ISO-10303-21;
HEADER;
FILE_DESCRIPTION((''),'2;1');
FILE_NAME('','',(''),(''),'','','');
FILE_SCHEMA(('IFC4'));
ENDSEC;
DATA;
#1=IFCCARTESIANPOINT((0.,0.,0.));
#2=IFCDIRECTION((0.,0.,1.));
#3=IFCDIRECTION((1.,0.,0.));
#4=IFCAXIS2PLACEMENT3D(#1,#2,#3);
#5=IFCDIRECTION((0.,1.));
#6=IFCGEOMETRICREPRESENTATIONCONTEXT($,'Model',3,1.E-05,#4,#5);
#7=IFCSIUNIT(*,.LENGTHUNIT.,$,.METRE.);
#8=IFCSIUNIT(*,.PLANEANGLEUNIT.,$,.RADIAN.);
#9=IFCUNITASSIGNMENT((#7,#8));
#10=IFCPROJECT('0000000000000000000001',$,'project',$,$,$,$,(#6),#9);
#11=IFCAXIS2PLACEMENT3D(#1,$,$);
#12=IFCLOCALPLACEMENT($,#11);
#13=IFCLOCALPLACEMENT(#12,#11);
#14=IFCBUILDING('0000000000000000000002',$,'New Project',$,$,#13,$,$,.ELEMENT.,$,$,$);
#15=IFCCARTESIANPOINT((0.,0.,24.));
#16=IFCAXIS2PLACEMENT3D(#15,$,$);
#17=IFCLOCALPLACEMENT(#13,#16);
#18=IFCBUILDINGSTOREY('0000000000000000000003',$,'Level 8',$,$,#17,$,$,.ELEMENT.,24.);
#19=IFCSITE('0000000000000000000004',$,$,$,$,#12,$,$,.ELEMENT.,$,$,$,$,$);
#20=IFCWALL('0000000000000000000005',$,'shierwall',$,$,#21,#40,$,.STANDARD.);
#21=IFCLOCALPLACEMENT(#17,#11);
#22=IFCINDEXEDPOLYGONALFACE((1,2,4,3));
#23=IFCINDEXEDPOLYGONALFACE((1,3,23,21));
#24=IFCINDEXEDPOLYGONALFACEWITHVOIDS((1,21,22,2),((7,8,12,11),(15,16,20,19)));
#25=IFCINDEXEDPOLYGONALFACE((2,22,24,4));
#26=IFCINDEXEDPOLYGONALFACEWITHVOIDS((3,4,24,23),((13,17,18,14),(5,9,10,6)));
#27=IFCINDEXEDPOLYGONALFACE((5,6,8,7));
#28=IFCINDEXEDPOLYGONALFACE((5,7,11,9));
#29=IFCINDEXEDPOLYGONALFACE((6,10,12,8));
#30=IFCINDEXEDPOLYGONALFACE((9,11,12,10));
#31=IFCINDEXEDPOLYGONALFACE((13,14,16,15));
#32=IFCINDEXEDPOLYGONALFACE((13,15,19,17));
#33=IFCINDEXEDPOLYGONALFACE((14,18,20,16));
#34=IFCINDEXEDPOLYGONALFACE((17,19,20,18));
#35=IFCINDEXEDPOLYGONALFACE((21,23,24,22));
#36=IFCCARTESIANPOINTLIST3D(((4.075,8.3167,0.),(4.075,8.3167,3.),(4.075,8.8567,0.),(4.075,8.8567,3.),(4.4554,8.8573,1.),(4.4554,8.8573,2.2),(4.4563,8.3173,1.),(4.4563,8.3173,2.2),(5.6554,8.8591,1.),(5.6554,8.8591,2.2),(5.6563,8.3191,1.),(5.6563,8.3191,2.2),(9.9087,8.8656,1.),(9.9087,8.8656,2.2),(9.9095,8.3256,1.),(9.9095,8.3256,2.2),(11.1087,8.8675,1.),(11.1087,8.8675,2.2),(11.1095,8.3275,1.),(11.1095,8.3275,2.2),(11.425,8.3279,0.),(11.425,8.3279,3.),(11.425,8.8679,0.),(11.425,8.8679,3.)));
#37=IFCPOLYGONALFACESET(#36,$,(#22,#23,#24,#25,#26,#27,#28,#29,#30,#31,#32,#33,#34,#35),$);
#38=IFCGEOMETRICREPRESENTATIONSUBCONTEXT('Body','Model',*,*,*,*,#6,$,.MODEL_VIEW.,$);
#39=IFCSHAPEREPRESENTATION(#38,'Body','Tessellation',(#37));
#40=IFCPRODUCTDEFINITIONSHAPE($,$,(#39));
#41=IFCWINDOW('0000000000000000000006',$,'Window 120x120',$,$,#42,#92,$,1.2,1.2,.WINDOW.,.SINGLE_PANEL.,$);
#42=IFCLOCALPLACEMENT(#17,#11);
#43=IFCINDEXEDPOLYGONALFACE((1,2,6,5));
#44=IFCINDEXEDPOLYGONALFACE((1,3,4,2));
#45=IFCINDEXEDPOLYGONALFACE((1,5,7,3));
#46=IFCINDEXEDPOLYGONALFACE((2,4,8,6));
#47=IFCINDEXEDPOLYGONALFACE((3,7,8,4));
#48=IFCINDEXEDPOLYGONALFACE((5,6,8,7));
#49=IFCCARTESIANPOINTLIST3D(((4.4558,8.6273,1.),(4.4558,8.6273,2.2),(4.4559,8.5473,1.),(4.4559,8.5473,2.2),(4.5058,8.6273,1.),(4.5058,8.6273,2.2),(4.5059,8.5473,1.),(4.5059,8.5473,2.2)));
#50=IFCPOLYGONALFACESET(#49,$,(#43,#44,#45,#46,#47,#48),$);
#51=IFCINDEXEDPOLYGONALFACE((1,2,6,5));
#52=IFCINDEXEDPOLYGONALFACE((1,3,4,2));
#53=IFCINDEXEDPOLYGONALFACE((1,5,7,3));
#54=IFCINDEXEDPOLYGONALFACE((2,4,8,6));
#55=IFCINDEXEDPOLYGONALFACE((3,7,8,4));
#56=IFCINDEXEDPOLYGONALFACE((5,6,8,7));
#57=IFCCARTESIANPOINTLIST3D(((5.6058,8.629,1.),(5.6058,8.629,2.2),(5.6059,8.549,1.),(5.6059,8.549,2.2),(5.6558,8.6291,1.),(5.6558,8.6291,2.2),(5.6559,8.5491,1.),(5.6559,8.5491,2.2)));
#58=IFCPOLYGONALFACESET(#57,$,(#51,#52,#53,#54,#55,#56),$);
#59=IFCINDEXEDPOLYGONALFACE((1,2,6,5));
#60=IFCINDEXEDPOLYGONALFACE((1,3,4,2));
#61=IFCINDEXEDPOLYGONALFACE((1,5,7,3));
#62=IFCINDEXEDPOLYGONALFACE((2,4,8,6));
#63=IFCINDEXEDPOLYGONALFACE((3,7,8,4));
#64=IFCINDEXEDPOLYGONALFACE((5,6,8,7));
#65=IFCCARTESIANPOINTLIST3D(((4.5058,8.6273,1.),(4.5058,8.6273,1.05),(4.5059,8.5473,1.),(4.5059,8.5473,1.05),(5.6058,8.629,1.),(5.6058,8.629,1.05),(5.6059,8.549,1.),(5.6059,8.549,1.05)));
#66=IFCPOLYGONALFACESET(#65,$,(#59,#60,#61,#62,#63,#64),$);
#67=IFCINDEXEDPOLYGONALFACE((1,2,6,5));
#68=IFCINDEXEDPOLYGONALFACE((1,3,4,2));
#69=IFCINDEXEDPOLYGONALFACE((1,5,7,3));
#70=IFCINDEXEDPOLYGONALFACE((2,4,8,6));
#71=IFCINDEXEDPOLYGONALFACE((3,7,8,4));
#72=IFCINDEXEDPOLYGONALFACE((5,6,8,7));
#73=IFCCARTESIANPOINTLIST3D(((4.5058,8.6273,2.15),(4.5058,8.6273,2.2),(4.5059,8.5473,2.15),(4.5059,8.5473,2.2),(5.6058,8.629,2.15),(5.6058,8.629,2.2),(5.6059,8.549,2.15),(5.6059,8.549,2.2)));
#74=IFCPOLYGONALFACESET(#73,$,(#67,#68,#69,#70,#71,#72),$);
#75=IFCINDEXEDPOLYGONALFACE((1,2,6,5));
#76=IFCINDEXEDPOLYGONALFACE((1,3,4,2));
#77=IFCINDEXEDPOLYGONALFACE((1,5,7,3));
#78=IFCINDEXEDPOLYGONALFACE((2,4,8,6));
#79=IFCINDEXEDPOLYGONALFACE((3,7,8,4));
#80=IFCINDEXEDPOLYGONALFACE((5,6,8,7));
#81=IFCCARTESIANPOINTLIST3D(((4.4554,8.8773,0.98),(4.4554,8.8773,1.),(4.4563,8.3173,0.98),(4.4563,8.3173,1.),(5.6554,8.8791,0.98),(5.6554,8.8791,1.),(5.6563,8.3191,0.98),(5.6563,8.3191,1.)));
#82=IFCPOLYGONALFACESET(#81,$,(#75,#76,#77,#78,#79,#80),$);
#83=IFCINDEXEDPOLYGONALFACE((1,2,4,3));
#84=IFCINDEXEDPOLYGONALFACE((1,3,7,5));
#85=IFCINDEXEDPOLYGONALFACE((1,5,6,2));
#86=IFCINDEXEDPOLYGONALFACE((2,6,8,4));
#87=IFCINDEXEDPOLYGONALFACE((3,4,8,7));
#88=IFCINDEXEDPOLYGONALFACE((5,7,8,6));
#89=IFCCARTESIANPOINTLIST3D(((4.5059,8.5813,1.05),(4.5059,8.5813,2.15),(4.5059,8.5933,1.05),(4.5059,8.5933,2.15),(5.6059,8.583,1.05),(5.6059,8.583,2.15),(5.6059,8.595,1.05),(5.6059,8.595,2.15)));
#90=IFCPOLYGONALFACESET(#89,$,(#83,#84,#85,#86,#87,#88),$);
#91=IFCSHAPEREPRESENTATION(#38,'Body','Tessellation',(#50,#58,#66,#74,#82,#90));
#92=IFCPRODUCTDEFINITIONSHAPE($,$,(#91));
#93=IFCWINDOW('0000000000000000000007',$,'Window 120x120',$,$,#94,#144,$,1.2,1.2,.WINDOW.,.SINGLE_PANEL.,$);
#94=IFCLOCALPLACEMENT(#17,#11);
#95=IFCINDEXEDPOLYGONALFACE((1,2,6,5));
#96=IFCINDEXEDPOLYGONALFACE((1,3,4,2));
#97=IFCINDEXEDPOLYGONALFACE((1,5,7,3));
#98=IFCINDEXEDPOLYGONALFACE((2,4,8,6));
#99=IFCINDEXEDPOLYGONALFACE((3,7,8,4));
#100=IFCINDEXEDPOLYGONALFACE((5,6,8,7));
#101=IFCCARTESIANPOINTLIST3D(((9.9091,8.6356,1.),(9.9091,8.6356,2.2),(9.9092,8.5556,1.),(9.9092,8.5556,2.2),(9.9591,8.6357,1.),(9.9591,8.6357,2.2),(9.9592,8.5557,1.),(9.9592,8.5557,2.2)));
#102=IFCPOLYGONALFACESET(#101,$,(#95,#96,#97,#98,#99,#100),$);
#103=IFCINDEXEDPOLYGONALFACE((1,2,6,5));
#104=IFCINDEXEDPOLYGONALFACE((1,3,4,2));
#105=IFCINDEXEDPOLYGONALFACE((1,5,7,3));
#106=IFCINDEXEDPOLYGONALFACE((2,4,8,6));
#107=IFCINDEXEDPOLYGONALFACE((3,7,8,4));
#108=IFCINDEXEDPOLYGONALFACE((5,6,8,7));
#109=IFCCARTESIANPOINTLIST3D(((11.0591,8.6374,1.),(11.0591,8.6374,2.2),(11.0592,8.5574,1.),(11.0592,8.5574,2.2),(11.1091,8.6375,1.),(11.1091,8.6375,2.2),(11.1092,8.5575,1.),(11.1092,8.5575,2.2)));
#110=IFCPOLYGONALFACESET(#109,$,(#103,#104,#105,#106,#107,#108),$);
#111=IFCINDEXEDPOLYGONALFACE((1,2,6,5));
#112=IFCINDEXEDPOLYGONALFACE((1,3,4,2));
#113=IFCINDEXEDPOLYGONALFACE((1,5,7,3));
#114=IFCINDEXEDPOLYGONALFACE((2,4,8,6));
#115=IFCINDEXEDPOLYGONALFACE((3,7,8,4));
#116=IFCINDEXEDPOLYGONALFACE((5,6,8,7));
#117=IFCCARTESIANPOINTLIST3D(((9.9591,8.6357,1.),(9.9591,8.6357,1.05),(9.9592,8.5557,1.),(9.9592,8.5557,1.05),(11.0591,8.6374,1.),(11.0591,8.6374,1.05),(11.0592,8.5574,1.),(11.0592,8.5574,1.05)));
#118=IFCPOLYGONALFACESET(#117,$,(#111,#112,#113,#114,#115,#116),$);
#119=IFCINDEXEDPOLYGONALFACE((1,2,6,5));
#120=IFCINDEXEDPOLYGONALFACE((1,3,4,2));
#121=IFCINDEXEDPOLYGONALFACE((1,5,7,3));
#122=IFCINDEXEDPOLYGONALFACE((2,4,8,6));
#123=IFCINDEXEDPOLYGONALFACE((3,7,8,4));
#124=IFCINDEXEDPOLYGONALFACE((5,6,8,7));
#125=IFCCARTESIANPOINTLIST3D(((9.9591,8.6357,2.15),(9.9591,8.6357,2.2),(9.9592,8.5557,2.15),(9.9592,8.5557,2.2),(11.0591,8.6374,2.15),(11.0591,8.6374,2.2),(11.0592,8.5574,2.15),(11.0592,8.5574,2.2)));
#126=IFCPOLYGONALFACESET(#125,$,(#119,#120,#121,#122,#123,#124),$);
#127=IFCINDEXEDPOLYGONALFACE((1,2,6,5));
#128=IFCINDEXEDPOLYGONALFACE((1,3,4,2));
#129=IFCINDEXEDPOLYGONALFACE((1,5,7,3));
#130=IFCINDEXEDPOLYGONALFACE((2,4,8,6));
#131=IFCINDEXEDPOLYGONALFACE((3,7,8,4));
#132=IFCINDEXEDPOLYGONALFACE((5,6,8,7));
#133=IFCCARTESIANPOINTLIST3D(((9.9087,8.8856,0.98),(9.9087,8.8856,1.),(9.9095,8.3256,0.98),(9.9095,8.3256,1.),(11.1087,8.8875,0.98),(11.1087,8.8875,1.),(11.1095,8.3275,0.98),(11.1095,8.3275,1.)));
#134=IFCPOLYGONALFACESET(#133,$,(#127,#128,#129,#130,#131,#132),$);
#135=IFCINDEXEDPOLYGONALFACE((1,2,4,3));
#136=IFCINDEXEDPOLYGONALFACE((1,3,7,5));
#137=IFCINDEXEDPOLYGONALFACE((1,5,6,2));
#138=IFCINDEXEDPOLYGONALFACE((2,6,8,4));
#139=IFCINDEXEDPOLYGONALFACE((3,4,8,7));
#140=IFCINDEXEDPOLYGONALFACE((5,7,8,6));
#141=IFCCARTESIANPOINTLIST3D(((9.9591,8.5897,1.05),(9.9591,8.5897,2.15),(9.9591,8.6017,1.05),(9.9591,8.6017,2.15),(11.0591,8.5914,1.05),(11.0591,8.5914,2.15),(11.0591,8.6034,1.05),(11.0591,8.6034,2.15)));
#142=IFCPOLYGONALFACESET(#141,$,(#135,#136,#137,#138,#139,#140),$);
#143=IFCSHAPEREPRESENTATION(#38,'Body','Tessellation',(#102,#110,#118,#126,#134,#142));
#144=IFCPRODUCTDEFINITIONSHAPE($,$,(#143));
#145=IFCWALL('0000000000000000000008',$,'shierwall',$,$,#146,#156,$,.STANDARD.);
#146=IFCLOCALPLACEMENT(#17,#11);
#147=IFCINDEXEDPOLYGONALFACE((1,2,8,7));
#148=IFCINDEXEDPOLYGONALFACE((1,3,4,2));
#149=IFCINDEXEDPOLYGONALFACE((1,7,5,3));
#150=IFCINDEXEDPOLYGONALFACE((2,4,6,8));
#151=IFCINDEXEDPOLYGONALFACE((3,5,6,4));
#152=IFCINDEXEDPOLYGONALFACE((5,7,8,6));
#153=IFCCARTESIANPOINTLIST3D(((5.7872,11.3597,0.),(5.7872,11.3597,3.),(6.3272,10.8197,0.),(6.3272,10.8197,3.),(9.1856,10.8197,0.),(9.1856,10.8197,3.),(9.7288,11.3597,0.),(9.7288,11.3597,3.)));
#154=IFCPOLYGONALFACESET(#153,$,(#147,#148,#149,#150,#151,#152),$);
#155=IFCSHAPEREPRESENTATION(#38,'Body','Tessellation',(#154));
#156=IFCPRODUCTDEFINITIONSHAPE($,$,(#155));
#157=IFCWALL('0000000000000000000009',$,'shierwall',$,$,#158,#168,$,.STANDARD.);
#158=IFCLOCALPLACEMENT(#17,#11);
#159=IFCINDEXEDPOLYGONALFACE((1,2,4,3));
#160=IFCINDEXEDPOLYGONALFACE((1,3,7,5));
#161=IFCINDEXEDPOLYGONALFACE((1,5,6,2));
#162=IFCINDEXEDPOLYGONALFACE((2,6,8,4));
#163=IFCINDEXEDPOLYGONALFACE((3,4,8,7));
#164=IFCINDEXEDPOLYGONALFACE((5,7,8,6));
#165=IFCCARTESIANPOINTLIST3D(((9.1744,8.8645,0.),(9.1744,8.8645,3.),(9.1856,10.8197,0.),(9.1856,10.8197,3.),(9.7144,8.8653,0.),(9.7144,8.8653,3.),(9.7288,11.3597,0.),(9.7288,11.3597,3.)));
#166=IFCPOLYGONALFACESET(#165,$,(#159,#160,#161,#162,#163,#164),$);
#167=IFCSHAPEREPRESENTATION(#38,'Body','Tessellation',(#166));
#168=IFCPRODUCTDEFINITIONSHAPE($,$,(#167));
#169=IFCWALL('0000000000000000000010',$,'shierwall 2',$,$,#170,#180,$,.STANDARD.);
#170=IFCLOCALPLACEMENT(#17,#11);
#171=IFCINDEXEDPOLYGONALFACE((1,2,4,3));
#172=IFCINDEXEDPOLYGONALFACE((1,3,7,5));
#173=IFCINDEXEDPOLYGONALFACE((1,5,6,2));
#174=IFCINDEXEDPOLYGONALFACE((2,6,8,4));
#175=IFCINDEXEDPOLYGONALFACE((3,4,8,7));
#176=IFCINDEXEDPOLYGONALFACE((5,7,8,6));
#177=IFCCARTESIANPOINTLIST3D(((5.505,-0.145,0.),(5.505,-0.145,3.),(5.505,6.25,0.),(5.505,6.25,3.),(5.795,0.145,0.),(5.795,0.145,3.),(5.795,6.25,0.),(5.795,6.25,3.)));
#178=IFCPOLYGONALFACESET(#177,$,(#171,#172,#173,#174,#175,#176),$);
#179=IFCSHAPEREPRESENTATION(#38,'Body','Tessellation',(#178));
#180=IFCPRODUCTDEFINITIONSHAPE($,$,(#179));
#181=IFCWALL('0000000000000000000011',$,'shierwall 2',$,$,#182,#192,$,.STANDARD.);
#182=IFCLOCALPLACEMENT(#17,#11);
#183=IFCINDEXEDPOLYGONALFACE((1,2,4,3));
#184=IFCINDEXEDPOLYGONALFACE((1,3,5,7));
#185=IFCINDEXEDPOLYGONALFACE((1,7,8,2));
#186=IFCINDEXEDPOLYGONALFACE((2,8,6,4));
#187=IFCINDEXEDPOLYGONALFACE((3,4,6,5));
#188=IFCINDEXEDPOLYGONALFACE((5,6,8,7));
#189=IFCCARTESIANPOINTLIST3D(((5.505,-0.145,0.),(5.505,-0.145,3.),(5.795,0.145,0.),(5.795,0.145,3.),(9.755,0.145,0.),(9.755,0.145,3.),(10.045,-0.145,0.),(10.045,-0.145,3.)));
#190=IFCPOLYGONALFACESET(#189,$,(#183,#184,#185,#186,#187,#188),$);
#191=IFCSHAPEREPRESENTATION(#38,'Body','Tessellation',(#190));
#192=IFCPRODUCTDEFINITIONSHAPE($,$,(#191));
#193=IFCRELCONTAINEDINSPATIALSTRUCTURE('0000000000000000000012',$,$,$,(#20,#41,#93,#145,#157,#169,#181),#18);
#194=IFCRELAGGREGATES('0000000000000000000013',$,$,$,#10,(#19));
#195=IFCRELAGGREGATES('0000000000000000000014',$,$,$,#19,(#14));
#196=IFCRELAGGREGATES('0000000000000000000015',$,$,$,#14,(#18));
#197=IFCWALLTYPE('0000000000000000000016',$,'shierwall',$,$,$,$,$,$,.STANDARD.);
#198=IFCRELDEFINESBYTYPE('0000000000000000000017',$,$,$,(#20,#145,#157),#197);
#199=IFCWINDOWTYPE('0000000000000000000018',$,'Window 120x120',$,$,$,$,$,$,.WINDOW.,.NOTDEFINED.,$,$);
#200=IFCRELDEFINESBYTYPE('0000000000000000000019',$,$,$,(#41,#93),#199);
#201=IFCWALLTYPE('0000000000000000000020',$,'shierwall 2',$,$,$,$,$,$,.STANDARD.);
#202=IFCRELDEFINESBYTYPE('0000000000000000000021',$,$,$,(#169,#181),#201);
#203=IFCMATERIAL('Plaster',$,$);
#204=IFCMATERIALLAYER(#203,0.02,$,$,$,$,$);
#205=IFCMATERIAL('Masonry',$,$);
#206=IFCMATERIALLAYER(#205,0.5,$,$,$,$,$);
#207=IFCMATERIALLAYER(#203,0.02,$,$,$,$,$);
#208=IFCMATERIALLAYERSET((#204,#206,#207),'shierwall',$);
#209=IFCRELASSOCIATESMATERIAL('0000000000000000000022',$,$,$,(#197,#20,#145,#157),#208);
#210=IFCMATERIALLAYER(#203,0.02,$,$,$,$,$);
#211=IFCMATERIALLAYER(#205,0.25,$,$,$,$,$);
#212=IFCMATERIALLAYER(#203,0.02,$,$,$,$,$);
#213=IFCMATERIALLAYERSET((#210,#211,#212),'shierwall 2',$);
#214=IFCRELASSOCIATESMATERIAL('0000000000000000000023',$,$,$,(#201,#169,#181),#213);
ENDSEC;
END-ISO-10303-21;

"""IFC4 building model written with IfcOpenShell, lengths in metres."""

from ifc_helpers import new_model, si_unit, direction, frame, frame_2d, origin, origin_with_axes, place, context, subcontext, project, spatial, polyline, rectangle, outline, extrude, material, layer, layer_set, layer_usage, type_object, element, fill, save


model = new_model("IFC4")

# Units and contexts
model_context = context("Model", 3, precision=1e-05, world=origin_with_axes(), true_north=direction((0.0, 1.0)))
body_context = subcontext(model_context, "Body", "Model", "MODEL_VIEW")
ifc_project = project(units=[si_unit("LENGTHUNIT", "METRE"), si_unit("PLANEANGLEUNIT", "RADIAN")], contexts=[model_context])

# Site, building, storey
site_placement = place(None, origin())
site = spatial("IfcSite", under=ifc_project, at=site_placement, CompositionType="ELEMENT")
building_placement = place(site_placement, origin())
building = spatial("IfcBuilding", under=site, at=building_placement, Name="New Project", CompositionType="ELEMENT")
storey_placement = place(building_placement, frame((0.0, 0.0, 24.0)))
storey = spatial("IfcBuildingStorey", under=building, at=storey_placement, Name="Level 8", CompositionType="ELEMENT", Elevation=24.0)

# Shared definitions
ifc_material_1 = material(Name="Plaster")
ifc_material_2 = material(Name="Masonry")

# Shared definitions
window_type = type_object("IfcWindowType", Name="Window 120x120", PartitioningType="NOTDEFINED", PredefinedType="WINDOW")

# Wall, openings, windows
ifc_layer_1 = layer(ifc_material_1, 0.02)
ifc_layer_2 = layer(ifc_material_2, 0.5)
ifc_layer_3 = layer(ifc_material_1, 0.02)
ifc_layer_set_1 = layer_set([ifc_layer_1, ifc_layer_2, ifc_layer_3], Name="shierwall")
ifc_layer_usage_1 = layer_usage(ifc_layer_set_1, "AXIS2", "NEGATIVE", 0.27)
wall_type_1 = type_object("IfcWallType", Name="shierwall", PredefinedType="STANDARD", material=ifc_layer_set_1)
wall_1_placement = place(storey_placement, frame((4.075, 8.5867, 0.0), z_axis=(0.0, 0.0, 1.0), x_axis=(0.999999, 0.001534, 0.0)))
wall_1 = element("IfcWall", 1, at=wall_1_placement, inside=storey, type_object=wall_type_1, material=ifc_layer_usage_1, Name="shierwall", PredefinedType="STANDARD", context=body_context, shape_type="SweptSolid", body=[
    extrude(outline(polyline([(-0.0004, -0.27), (7.3496, -0.27), (7.3504, 0.27), (0.0004, 0.27), (-0.0004, -0.27)])), origin(), (0.0, 0.0, 1.0), 3.0),
])
opening_1_placement = place(wall_1_placement, frame((0.3809, 0.0, 1.0)))
opening_1 = element("IfcOpeningElement", 2, at=opening_1_placement, cuts=wall_1, PredefinedType="OPENING", context=body_context, shape_type="SweptSolid", body=[
    extrude(rectangle(XDim=1.2, YDim=0.64, at=frame_2d((0.6, 0.0))), origin(), (0.0, 0.0, 1.0), 1.2),
])
opening_2_placement = place(wall_1_placement, frame((5.8341, 0.0, 1.0)))
opening_2 = element("IfcOpeningElement", 3, at=opening_2_placement, cuts=wall_1, PredefinedType="OPENING", context=body_context, shape_type="SweptSolid", body=[
    extrude(rectangle(XDim=1.2, YDim=0.64, at=frame_2d((0.6, 0.0))), origin(), (0.0, 0.0, 1.0), 1.2),
])
window_1_placement = place(opening_1_placement, origin())
window_1 = element("IfcWindow", 4, at=window_1_placement, inside=storey, type_object=window_type, Name="Window 120x120", OverallHeight=1.2, OverallWidth=1.2, PartitioningType="SINGLE_PANEL", PredefinedType="WINDOW", context=body_context, shape_type="SweptSolid", body=[
    extrude(outline(polyline([(0.0, -0.04), (0.05, -0.04), (0.05, 0.04), (0.0, 0.04), (0.0, -0.04)])), origin(), (0.0, 0.0, 1.0), 1.2),
    extrude(outline(polyline([(1.15, -0.04), (1.2, -0.04), (1.2, 0.04), (1.15, 0.04), (1.15, -0.04)])), origin(), (0.0, 0.0, 1.0), 1.2),
    extrude(outline(polyline([(0.05, -0.04), (1.15, -0.04), (1.15, 0.04), (0.05, 0.04), (0.05, -0.04)])), origin(), (0.0, 0.0, 1.0), 0.05),
    extrude(outline(polyline([(0.05, -0.04), (1.15, -0.04), (1.15, 0.04), (0.05, 0.04), (0.05, -0.04)])), frame((0.0, 0.0, 1.15)), (0.0, 0.0, 1.0), 0.05),
    extrude(outline(polyline([(0.0, -0.27), (1.2, -0.27), (1.2, 0.29), (0.0, 0.29), (0.0, -0.27)])), frame((0.0, 0.0, -0.02)), (0.0, 0.0, 1.0), 0.02),
    extrude(outline(polyline([(0.05, -0.006), (1.15, -0.006), (1.15, 0.006), (0.05, 0.006), (0.05, -0.006)])), frame((0.0, 0.0, 0.05)), (0.0, 0.0, 1.0), 1.1),
])
fill(opening_1, window_1)
window_2_placement = place(opening_2_placement, origin())
window_2 = element("IfcWindow", 5, at=window_2_placement, inside=storey, type_object=window_type, Name="Window 120x120", OverallHeight=1.2, OverallWidth=1.2, PartitioningType="SINGLE_PANEL", PredefinedType="WINDOW", context=body_context, shape_type="SweptSolid", body=[
    extrude(outline(polyline([(0.0, -0.04), (0.05, -0.04), (0.05, 0.04), (0.0, 0.04), (0.0, -0.04)])), origin(), (0.0, 0.0, 1.0), 1.2),
    extrude(outline(polyline([(1.15, -0.04), (1.2, -0.04), (1.2, 0.04), (1.15, 0.04), (1.15, -0.04)])), origin(), (0.0, 0.0, 1.0), 1.2),
    extrude(outline(polyline([(0.05, -0.04), (1.15, -0.04), (1.15, 0.04), (0.05, 0.04), (0.05, -0.04)])), origin(), (0.0, 0.0, 1.0), 0.05),
    extrude(outline(polyline([(0.05, -0.04), (1.15, -0.04), (1.15, 0.04), (0.05, 0.04), (0.05, -0.04)])), frame((0.0, 0.0, 1.15)), (0.0, 0.0, 1.0), 0.05),
    extrude(outline(polyline([(0.0, -0.27), (1.2, -0.27), (1.2, 0.29), (0.0, 0.29), (0.0, -0.27)])), frame((0.0, 0.0, -0.02)), (0.0, 0.0, 1.0), 0.02),
    extrude(outline(polyline([(0.05, -0.006), (1.15, -0.006), (1.15, 0.006), (0.05, 0.006), (0.05, -0.006)])), frame((0.0, 0.0, 0.05)), (0.0, 0.0, 1.0), 1.1),
])
fill(opening_2, window_2)

# Walls
wall_2_placement = place(storey_placement, frame((6.0572, 11.0897, 0.0)))
element("IfcWall", 6, at=wall_2_placement, inside=storey, type_object=wall_type_1, material=ifc_layer_usage_1, Name="shierwall", PredefinedType="STANDARD", context=body_context, shape_type="SweptSolid", body=[
    extrude(outline(polyline([(0.27, -0.27), (3.1284, -0.27), (3.6716, 0.27), (-0.27, 0.27), (0.27, -0.27)])), origin(), (0.0, 0.0, 1.0), 3.0),
])
wall_3_placement = place(storey_placement, frame((9.4572, 11.0897, 0.0), z_axis=(0.0, 0.0, 1.0), x_axis=(-0.005766, -0.999983, 0.0)))
element("IfcWall", 7, at=wall_3_placement, inside=storey, type_object=wall_type_1, material=ifc_layer_usage_1, Name="shierwall", PredefinedType="STANDARD", context=body_context, shape_type="SweptSolid", body=[
    extrude(outline(polyline([(0.2716, -0.27), (2.2268, -0.27), (2.2229, 0.27), (-0.2716, 0.27), (0.2716, -0.27)])), origin(), (0.0, 0.0, 1.0), 3.0),
])
ifc_layer_4 = layer(ifc_material_1, 0.02)
ifc_layer_5 = layer(ifc_material_2, 0.25)
ifc_layer_6 = layer(ifc_material_1, 0.02)
ifc_layer_set_2 = layer_set([ifc_layer_4, ifc_layer_5, ifc_layer_6], Name="shierwall 2")
ifc_layer_usage_2 = layer_usage(ifc_layer_set_2, "AXIS2", "NEGATIVE", 0.145)
wall_type_2 = type_object("IfcWallType", Name="shierwall 2", PredefinedType="STANDARD", material=ifc_layer_set_2)
wall_4_placement = place(storey_placement, frame((5.65, 6.25, 0.0), z_axis=(0.0, 0.0, 1.0), x_axis=(0.0, -1.0, 0.0)))
element("IfcWall", 8, at=wall_4_placement, inside=storey, type_object=wall_type_2, material=ifc_layer_usage_2, Name="shierwall 2", PredefinedType="STANDARD", context=body_context, shape_type="SweptSolid", body=[
    extrude(outline(polyline([(0.0, -0.145), (6.395, -0.145), (6.105, 0.145), (0.0, 0.145), (0.0, -0.145)])), origin(), (0.0, 0.0, 1.0), 3.0),
])
wall_5_placement = place(storey_placement, frame((5.65, 0.0, 0.0)))
element("IfcWall", 9, at=wall_5_placement, inside=storey, type_object=wall_type_2, material=ifc_layer_usage_2, Name="shierwall 2", PredefinedType="STANDARD", context=body_context, shape_type="SweptSolid", body=[
    extrude(outline(polyline([(-0.145, -0.145), (4.395, -0.145), (4.105, 0.145), (0.145, 0.145), (-0.145, -0.145)])), origin(), (0.0, 0.0, 1.0), 3.0),
])

save(model, "model.ifc")
